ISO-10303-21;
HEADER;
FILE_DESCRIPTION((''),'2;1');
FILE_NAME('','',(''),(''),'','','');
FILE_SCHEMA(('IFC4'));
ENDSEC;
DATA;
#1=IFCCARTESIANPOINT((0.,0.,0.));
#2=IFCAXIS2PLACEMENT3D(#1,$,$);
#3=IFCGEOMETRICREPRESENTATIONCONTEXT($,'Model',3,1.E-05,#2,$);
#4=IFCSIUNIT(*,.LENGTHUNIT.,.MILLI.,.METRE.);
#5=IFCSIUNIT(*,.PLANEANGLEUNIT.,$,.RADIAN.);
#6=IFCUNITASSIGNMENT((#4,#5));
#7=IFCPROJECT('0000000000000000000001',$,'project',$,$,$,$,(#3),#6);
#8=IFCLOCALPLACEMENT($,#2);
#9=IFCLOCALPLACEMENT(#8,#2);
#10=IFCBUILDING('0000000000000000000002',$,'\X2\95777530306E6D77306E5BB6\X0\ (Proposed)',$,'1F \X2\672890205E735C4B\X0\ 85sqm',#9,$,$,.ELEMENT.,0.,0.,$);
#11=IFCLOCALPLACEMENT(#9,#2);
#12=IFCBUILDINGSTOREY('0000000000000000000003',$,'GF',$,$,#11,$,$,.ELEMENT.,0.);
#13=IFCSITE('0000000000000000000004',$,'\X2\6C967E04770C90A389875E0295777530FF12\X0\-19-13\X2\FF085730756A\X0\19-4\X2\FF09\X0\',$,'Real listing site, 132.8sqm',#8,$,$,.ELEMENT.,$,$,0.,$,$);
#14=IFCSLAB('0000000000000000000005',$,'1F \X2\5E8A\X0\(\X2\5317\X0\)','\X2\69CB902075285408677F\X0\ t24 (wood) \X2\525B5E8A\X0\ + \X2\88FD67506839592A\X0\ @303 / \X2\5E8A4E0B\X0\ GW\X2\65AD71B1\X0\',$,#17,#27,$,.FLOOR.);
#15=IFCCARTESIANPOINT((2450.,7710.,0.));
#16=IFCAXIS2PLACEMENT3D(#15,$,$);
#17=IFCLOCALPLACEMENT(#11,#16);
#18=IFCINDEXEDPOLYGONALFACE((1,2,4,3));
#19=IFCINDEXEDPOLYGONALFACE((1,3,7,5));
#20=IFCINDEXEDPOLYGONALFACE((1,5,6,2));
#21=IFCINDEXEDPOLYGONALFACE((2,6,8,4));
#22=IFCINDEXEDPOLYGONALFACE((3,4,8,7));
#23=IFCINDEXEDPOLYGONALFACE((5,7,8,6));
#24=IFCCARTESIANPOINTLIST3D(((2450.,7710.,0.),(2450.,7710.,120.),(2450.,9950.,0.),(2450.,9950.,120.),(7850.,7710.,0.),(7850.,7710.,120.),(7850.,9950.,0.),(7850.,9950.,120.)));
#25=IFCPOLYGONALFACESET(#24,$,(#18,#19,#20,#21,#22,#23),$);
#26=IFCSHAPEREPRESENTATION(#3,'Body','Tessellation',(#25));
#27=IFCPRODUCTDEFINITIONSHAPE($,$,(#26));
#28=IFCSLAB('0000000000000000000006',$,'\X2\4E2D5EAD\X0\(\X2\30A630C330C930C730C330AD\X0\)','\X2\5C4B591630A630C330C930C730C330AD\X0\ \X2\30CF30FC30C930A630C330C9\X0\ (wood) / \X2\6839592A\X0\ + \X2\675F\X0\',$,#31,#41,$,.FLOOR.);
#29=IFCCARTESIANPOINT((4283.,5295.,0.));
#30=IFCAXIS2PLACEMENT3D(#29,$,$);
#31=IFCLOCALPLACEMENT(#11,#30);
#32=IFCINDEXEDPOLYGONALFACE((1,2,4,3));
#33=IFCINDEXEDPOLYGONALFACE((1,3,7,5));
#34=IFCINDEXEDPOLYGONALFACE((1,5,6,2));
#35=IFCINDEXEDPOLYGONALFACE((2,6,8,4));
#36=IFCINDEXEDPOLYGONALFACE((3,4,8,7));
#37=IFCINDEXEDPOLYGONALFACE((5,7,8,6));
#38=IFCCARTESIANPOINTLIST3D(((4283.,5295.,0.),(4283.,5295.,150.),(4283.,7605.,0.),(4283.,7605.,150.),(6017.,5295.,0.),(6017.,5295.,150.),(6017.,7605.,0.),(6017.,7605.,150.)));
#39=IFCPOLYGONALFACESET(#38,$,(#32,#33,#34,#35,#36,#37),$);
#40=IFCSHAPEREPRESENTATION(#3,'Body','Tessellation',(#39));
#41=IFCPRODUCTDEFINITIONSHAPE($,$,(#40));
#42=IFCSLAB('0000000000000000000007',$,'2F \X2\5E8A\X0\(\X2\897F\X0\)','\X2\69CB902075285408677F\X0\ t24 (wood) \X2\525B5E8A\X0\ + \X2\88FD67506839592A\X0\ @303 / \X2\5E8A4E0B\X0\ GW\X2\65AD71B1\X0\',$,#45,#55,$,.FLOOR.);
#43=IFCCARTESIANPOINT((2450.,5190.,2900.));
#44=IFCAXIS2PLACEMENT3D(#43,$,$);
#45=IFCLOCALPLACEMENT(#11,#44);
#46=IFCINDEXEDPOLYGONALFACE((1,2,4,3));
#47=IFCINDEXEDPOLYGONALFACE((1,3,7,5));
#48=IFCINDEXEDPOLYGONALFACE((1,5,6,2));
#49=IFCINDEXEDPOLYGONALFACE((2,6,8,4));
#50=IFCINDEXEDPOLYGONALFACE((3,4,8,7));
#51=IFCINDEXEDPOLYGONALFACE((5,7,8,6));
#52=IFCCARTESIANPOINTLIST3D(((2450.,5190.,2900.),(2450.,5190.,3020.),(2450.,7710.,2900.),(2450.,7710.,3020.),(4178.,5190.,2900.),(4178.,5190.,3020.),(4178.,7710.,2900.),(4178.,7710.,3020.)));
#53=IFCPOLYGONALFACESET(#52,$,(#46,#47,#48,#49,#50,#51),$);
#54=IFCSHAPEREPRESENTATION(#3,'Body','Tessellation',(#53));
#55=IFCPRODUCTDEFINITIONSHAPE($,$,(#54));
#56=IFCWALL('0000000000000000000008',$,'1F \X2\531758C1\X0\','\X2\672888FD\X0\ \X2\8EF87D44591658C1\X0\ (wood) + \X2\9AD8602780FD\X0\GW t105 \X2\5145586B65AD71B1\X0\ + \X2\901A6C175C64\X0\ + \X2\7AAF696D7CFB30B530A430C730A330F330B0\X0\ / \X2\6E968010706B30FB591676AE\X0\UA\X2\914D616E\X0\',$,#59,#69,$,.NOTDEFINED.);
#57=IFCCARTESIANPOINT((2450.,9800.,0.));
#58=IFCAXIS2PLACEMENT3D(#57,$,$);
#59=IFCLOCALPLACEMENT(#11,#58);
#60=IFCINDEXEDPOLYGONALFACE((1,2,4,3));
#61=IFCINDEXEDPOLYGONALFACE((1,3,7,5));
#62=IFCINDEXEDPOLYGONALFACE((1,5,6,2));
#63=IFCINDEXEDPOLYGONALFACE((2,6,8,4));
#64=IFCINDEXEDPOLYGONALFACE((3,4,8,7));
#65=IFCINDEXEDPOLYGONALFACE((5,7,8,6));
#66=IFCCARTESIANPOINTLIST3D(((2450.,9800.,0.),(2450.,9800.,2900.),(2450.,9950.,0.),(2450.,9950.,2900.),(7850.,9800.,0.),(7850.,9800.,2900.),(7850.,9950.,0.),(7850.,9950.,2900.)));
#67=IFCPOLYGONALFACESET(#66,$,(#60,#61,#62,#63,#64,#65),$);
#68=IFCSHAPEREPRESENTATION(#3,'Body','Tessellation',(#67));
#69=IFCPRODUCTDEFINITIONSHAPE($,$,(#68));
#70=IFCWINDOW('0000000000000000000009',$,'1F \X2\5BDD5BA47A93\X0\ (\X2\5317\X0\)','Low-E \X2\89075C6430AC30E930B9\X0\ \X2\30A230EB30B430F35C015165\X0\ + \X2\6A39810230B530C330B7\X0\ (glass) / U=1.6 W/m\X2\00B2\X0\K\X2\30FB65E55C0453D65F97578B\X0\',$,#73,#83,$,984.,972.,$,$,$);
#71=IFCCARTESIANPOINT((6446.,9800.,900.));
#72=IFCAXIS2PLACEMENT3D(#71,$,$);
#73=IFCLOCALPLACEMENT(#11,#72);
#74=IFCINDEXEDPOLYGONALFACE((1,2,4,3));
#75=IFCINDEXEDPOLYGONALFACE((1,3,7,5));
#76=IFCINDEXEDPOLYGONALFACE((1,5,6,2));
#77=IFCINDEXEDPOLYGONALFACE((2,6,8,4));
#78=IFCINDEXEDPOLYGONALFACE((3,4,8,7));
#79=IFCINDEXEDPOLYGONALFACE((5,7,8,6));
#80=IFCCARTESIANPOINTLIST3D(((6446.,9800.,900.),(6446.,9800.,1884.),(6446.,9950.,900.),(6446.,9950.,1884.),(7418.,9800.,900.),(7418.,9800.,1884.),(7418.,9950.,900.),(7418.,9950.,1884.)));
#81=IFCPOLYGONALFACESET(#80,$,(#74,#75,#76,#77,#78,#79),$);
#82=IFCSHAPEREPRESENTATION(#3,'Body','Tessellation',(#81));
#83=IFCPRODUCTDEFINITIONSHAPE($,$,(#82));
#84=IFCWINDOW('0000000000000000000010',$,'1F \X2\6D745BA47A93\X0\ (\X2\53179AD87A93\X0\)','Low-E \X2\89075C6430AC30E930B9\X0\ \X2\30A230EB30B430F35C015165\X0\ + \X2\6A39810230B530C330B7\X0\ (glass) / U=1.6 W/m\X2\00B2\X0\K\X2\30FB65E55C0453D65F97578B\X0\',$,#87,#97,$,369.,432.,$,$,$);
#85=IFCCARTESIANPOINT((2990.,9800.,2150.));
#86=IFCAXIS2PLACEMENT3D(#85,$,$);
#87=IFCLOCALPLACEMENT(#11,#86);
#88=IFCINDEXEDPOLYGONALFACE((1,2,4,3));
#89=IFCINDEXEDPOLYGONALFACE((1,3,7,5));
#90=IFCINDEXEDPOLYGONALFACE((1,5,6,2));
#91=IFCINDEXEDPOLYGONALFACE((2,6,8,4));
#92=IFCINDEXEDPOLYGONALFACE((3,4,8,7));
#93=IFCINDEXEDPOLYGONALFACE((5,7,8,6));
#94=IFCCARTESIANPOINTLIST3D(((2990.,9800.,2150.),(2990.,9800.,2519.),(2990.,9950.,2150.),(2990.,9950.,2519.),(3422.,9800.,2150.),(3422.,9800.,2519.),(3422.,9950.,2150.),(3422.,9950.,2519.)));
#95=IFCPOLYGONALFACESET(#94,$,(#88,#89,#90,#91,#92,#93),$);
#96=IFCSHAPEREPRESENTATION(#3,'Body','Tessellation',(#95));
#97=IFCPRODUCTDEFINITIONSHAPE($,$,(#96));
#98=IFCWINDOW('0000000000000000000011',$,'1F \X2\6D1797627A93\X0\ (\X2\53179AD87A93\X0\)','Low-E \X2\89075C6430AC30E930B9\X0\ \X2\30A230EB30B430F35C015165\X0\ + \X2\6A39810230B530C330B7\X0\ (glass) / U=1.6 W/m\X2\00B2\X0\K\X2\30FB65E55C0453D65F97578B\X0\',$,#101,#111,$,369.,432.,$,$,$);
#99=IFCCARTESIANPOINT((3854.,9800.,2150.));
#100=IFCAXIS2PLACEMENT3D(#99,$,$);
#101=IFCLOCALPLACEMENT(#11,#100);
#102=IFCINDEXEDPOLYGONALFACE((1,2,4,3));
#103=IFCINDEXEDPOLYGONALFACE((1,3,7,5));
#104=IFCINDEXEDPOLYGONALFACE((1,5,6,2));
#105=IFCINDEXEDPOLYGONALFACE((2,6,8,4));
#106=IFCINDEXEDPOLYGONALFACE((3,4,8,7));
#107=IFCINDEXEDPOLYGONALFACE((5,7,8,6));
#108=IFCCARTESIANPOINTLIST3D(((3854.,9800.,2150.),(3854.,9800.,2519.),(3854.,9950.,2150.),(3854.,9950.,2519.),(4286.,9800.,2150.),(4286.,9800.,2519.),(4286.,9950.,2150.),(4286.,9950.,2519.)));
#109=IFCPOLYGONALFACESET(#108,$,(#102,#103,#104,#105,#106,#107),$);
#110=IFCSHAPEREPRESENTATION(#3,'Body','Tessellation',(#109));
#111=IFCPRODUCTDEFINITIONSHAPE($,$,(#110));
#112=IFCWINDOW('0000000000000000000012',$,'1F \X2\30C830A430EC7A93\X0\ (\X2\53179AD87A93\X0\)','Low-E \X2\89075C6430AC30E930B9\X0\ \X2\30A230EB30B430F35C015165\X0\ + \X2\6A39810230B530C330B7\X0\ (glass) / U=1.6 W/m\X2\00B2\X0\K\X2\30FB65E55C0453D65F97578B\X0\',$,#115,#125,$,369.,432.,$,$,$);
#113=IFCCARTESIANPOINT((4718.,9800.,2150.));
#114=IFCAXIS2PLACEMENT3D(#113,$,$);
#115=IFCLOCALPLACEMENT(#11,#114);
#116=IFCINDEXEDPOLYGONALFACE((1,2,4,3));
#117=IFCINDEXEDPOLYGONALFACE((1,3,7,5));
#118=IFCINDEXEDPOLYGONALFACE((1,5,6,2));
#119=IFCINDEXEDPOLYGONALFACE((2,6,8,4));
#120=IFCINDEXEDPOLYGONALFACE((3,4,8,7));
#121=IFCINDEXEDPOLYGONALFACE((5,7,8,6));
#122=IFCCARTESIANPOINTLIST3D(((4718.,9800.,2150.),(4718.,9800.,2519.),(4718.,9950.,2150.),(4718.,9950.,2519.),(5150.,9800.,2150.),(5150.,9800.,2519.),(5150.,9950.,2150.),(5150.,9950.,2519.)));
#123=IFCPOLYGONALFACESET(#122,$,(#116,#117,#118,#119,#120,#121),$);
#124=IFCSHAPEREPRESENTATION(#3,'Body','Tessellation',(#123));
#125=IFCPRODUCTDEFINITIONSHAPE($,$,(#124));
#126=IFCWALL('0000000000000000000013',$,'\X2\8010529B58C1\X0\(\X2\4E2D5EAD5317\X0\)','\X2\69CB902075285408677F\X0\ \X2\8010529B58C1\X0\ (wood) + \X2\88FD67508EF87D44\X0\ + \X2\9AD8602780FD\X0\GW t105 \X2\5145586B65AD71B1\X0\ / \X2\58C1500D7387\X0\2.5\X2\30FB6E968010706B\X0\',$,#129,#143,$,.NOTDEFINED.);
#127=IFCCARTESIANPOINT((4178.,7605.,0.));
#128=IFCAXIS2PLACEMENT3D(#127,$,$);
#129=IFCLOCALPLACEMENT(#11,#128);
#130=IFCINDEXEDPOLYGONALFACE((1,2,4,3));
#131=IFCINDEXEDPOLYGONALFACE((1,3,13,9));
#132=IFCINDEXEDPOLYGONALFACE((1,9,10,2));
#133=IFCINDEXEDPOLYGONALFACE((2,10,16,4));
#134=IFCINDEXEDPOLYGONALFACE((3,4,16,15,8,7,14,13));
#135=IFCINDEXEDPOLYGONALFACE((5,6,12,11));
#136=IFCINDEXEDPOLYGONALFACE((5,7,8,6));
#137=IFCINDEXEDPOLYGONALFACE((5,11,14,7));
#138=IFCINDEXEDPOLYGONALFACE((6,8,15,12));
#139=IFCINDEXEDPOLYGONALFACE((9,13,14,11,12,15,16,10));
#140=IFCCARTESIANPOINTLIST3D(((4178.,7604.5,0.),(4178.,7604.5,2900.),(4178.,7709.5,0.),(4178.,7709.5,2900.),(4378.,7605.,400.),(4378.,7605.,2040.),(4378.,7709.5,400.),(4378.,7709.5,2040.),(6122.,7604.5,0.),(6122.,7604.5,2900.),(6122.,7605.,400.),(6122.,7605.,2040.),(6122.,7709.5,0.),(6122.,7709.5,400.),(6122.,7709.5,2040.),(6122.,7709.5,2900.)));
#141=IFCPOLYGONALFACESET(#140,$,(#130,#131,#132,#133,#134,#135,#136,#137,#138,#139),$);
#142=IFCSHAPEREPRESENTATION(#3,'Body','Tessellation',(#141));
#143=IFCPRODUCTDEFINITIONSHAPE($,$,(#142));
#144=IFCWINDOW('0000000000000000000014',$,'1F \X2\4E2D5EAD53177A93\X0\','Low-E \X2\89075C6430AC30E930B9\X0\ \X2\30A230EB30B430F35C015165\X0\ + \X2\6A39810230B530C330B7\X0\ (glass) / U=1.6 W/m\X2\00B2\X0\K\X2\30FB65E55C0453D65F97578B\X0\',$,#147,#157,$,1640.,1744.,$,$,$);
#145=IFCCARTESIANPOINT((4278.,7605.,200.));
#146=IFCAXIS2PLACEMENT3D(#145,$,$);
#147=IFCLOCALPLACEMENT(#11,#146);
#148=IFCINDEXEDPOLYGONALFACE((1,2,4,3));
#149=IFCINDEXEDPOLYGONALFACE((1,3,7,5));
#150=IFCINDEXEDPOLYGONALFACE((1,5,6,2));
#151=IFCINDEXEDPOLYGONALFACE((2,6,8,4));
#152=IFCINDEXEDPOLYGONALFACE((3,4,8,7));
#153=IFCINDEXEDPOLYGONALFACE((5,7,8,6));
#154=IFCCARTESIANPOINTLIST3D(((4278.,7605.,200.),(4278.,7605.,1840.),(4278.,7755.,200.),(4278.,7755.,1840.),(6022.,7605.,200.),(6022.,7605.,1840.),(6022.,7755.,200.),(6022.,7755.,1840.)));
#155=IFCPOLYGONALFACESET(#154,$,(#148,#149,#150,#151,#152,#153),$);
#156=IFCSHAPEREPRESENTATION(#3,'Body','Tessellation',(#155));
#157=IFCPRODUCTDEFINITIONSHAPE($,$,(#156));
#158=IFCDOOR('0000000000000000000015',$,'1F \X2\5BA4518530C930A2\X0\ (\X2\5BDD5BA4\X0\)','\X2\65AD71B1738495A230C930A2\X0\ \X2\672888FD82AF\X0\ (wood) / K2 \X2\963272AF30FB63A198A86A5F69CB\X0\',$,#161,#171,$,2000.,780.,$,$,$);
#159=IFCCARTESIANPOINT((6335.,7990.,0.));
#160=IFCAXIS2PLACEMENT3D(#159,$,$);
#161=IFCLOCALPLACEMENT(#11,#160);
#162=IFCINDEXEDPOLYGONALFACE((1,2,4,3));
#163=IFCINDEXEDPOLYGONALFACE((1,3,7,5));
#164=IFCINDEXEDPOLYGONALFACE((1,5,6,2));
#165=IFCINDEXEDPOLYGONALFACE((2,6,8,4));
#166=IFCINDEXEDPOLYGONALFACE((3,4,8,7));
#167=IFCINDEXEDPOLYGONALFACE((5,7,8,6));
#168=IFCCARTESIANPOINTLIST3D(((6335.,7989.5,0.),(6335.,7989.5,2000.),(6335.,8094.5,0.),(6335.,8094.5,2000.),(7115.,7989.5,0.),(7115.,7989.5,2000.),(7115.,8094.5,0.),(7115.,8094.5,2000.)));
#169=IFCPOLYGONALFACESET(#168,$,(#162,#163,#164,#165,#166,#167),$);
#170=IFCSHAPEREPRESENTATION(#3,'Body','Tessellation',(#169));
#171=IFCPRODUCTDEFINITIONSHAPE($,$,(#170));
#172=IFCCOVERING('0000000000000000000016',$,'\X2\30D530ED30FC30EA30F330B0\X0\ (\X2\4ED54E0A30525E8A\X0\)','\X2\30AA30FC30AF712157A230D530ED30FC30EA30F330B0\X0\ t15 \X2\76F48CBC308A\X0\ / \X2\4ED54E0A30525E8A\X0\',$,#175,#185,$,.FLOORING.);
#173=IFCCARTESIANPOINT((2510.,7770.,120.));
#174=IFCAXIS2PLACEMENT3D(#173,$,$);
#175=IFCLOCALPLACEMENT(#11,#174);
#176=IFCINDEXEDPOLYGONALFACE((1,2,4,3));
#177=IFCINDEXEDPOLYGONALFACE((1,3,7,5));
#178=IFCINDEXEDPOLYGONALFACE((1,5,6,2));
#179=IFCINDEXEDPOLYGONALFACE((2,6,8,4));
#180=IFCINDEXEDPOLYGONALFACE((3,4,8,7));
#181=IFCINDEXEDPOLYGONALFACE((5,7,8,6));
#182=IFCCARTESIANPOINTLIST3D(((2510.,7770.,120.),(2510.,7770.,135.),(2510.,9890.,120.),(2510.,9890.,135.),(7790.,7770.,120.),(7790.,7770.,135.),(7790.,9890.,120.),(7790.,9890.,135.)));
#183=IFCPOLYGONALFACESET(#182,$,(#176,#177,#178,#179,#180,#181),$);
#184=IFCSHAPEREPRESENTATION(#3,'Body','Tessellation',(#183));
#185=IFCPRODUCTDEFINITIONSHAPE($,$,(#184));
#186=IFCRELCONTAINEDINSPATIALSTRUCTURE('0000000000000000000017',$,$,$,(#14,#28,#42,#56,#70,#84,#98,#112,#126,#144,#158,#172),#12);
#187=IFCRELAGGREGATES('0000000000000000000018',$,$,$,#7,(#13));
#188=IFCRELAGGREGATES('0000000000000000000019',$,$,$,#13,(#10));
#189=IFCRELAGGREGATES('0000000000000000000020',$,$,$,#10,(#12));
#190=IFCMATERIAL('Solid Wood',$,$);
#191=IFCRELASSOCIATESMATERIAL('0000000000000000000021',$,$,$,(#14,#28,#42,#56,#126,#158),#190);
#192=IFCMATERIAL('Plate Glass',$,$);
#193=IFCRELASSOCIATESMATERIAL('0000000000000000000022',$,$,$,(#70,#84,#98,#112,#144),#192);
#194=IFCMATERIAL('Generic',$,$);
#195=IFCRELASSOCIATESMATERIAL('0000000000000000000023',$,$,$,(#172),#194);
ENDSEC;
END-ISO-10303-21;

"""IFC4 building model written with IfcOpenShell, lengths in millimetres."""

from ifc_helpers import new_model, si_unit, frame, frame_2d, origin, place, context, project, spatial, rectangle, extrude, material, element, fill, save


model = new_model("IFC4")

# Units and contexts
model_context = context("Model", 3, precision=1e-05, world=origin())
ifc_project = project(units=[si_unit("LENGTHUNIT", "METRE", prefix="MILLI"), si_unit("PLANEANGLEUNIT", "RADIAN")], contexts=[model_context])

# Site, building, storey
site_placement = place(None, origin())
site = spatial("IfcSite", under=ifc_project, at=site_placement, Name="沖縄県那覇市長田２-19-13（地番19-4）", ObjectType="Real listing site, 132.8sqm", CompositionType="ELEMENT", RefElevation=0.0)
building_placement = place(site_placement, origin())
building = spatial("IfcBuilding", under=site, at=building_placement, Name="長田の海の家 (Proposed)", ObjectType="1F 木造平屋 85sqm", CompositionType="ELEMENT", ElevationOfRefHeight=0.0, ElevationOfTerrain=0.0)
storey_placement = place(building_placement, origin())
storey = spatial("IfcBuildingStorey", under=building, at=storey_placement, Name="GF", CompositionType="ELEMENT", Elevation=0.0)

# Slabs
ifc_material_1 = material(Name="Solid Wood")
slab_1_placement = place(storey_placement, frame((2450.0, 7710.0, 0.0)))
element("IfcSlab", 1, at=slab_1_placement, inside=storey, material=ifc_material_1, Name="1F 床(北)", Description="構造用合板 t24 (wood) 剛床 + 製材根太 @303 / 床下 GW断熱", PredefinedType="FLOOR", context=model_context, shape_type="SweptSolid", body=[
    extrude(rectangle(XDim=5400.0, YDim=2240.0, at=frame_2d((2700.0, 1120.0))), frame((2450.0, 7710.0, 0.0)), (0.0, 0.0, 1.0), 120.0),
])
slab_2_placement = place(storey_placement, frame((4283.0, 5295.0, 0.0)))
element("IfcSlab", 2, at=slab_2_placement, inside=storey, material=ifc_material_1, Name="中庭(ウッドデッキ)", Description="屋外ウッドデッキ ハードウッド (wood) / 根太 + 束", PredefinedType="FLOOR", context=model_context, shape_type="SweptSolid", body=[
    extrude(rectangle(XDim=1734.0, YDim=2310.0, at=frame_2d((867.0, 1155.0))), frame((4283.0, 5295.0, 0.0)), (0.0, 0.0, 1.0), 150.0),
])
slab_3_placement = place(storey_placement, frame((2450.0, 5190.0, 2900.0)))
element("IfcSlab", 3, at=slab_3_placement, inside=storey, material=ifc_material_1, Name="2F 床(西)", Description="構造用合板 t24 (wood) 剛床 + 製材根太 @303 / 床下 GW断熱", PredefinedType="FLOOR", context=model_context, shape_type="SweptSolid", body=[
    extrude(rectangle(XDim=1728.0, YDim=2520.0, at=frame_2d((864.0, 1260.0))), frame((2450.0, 5190.0, 2900.0)), (0.0, 0.0, 1.0), 120.0),
])

# Wall, openings, windows
wall_1_placement = place(storey_placement, frame((2450.0, 9800.0, 0.0)))
wall_1 = element("IfcWall", 4, at=wall_1_placement, inside=storey, material=ifc_material_1, Name="1F 北壁", Description="木製 軸組外壁 (wood) + 高性能GW t105 充填断熱 + 通気層 + 窯業系サイディング / 準耐火・外皮UA配慮", PredefinedType="NOTDEFINED", context=model_context, shape_type="SweptSolid", body=[
    extrude(rectangle(XDim=5400.0, YDim=150.0, at=frame_2d((2700.0, 75.0))), frame((2450.0, 9800.0, 0.0)), (0.0, 0.0, 1.0), 2900.0),
])
opening_1_placement = place(storey_placement, frame((6446.0, 9800.0, 900.0)))
opening_1 = element("IfcOpeningElement", 5, at=opening_1_placement, cuts=wall_1, PredefinedType="NOTDEFINED", context=model_context, shape_type="SweptSolid", body=[
    extrude(rectangle(XDim=972.0, YDim=150.0, at=frame_2d((486.0, 75.0))), frame((6446.0, 9800.0, 900.0)), (0.0, 0.0, 1.0), 984.0),
])
opening_2_placement = place(storey_placement, frame((2990.0, 9800.0, 2150.0)))
opening_2 = element("IfcOpeningElement", 6, at=opening_2_placement, cuts=wall_1, PredefinedType="NOTDEFINED", context=model_context, shape_type="SweptSolid", body=[
    extrude(rectangle(XDim=432.0, YDim=150.0, at=frame_2d((216.0, 75.0))), frame((2990.0, 9800.0, 2150.0)), (0.0, 0.0, 1.0), 369.0),
])
opening_3_placement = place(storey_placement, frame((3854.0, 9800.0, 2150.0)))
opening_3 = element("IfcOpeningElement", 7, at=opening_3_placement, cuts=wall_1, PredefinedType="NOTDEFINED", context=model_context, shape_type="SweptSolid", body=[
    extrude(rectangle(XDim=432.0, YDim=150.0, at=frame_2d((216.0, 75.0))), frame((3854.0, 9800.0, 2150.0)), (0.0, 0.0, 1.0), 369.0),
])
opening_4_placement = place(storey_placement, frame((4718.0, 9800.0, 2150.0)))
opening_4 = element("IfcOpeningElement", 8, at=opening_4_placement, cuts=wall_1, PredefinedType="NOTDEFINED", context=model_context, shape_type="SweptSolid", body=[
    extrude(rectangle(XDim=432.0, YDim=150.0, at=frame_2d((216.0, 75.0))), frame((4718.0, 9800.0, 2150.0)), (0.0, 0.0, 1.0), 369.0),
])
ifc_material_2 = material(Name="Plate Glass")
window_1_placement = place(storey_placement, frame((6446.0, 9800.0, 900.0)))
window_1 = element("IfcWindow", 9, at=window_1_placement, inside=storey, material=ifc_material_2, Name="1F 寝室窓 (北)", Description="Low-E 複層ガラス アルゴン封入 + 樹脂サッシ (glass) / U=1.6 W/m²K・日射取得型", OverallHeight=984.0, OverallWidth=972.0, context=model_context, shape_type="SweptSolid", body=[
    extrude(rectangle(XDim=972.0, YDim=150.0, at=frame_2d((486.0, 75.0))), frame((6446.0, 9800.0, 900.0)), (0.0, 0.0, 1.0), 984.0),
])
fill(opening_1, window_1)
window_2_placement = place(storey_placement, frame((2990.0, 9800.0, 2150.0)))
window_2 = element("IfcWindow", 10, at=window_2_placement, inside=storey, material=ifc_material_2, Name="1F 浴室窓 (北高窓)", Description="Low-E 複層ガラス アルゴン封入 + 樹脂サッシ (glass) / U=1.6 W/m²K・日射取得型", OverallHeight=369.0, OverallWidth=432.0, context=model_context, shape_type="SweptSolid", body=[
    extrude(rectangle(XDim=432.0, YDim=150.0, at=frame_2d((216.0, 75.0))), frame((2990.0, 9800.0, 2150.0)), (0.0, 0.0, 1.0), 369.0),
])
fill(opening_2, window_2)
window_3_placement = place(storey_placement, frame((3854.0, 9800.0, 2150.0)))
window_3 = element("IfcWindow", 11, at=window_3_placement, inside=storey, material=ifc_material_2, Name="1F 洗面窓 (北高窓)", Description="Low-E 複層ガラス アルゴン封入 + 樹脂サッシ (glass) / U=1.6 W/m²K・日射取得型", OverallHeight=369.0, OverallWidth=432.0, context=model_context, shape_type="SweptSolid", body=[
    extrude(rectangle(XDim=432.0, YDim=150.0, at=frame_2d((216.0, 75.0))), frame((3854.0, 9800.0, 2150.0)), (0.0, 0.0, 1.0), 369.0),
])
fill(opening_3, window_3)
window_4_placement = place(storey_placement, frame((4718.0, 9800.0, 2150.0)))
window_4 = element("IfcWindow", 12, at=window_4_placement, inside=storey, material=ifc_material_2, Name="1F トイレ窓 (北高窓)", Description="Low-E 複層ガラス アルゴン封入 + 樹脂サッシ (glass) / U=1.6 W/m²K・日射取得型", OverallHeight=369.0, OverallWidth=432.0, context=model_context, shape_type="SweptSolid", body=[
    extrude(rectangle(XDim=432.0, YDim=150.0, at=frame_2d((216.0, 75.0))), frame((4718.0, 9800.0, 2150.0)), (0.0, 0.0, 1.0), 369.0),
])
fill(opening_4, window_4)

# Wall, opening, window
wall_2_placement = place(storey_placement, frame((4178.0, 7605.0, 0.0)))
wall_2 = element("IfcWall", 13, at=wall_2_placement, inside=storey, material=ifc_material_1, Name="耐力壁(中庭北)", Description="構造用合板 耐力壁 (wood) + 製材軸組 + 高性能GW t105 充填断熱 / 壁倍率2.5・準耐火", PredefinedType="NOTDEFINED", context=model_context, shape_type="SweptSolid", body=[
    extrude(rectangle(XDim=1944.0, YDim=105.0, at=frame_2d((972.0, 52.0))), frame((4178.0, 7605.0, 0.0)), (0.0, 0.0, 1.0), 2900.0),
])
opening_5_placement = place(storey_placement, frame((4278.0, 7605.0, 200.0)))
opening_5 = element("IfcOpeningElement", 14, at=opening_5_placement, cuts=wall_2, PredefinedType="NOTDEFINED", context=model_context, shape_type="SweptSolid", body=[
    extrude(rectangle(XDim=1744.0, YDim=150.0, at=frame_2d((872.0, 75.0))), frame((4278.0, 7605.0, 200.0)), (0.0, 0.0, 1.0), 1640.0),
])
window_5_placement = place(storey_placement, frame((4278.0, 7605.0, 200.0)))
window_5 = element("IfcWindow", 15, at=window_5_placement, inside=storey, material=ifc_material_2, Name="1F 中庭北窓", Description="Low-E 複層ガラス アルゴン封入 + 樹脂サッシ (glass) / U=1.6 W/m²K・日射取得型", OverallHeight=1640.0, OverallWidth=1744.0, context=model_context, shape_type="SweptSolid", body=[
    extrude(rectangle(XDim=1744.0, YDim=150.0, at=frame_2d((872.0, 75.0))), frame((4278.0, 7605.0, 200.0)), (0.0, 0.0, 1.0), 1640.0),
])
fill(opening_5, window_5)

# Door
door_1_placement = place(storey_placement, frame((6335.0, 7990.0, 0.0)))
element("IfcDoor", 16, at=door_1_placement, inside=storey, material=ifc_material_1, Name="1F 室内ドア (寝室)", Description="断熱玄関ドア 木製芯 (wood) / K2 防犯・採風機構", OverallHeight=2000.0, OverallWidth=780.0, context=model_context, shape_type="SweptSolid", body=[
    extrude(rectangle(XDim=780.0, YDim=105.0, at=frame_2d((390.0, 52.0))), frame((6335.0, 7990.0, 0.0)), (0.0, 0.0, 1.0), 2000.0),
])

# Covering
ifc_material_3 = material(Name="Generic")
covering_1_placement = place(storey_placement, frame((2510.0, 7770.0, 120.0)))
element("IfcCovering", 17, at=covering_1_placement, inside=storey, material=ifc_material_3, Name="フローリング (仕上げ床)", Description="オーク無垢フローリング t15 直貼り / 仕上げ床", PredefinedType="FLOORING", context=model_context, shape_type="SweptSolid", body=[
    extrude(rectangle(XDim=5280.0, YDim=2120.0, at=frame_2d((2640.0, 1060.0))), frame((2510.0, 7770.0, 120.0)), (0.0, 0.0, 1.0), 15.0),
])

save(model, "model.ifc")
